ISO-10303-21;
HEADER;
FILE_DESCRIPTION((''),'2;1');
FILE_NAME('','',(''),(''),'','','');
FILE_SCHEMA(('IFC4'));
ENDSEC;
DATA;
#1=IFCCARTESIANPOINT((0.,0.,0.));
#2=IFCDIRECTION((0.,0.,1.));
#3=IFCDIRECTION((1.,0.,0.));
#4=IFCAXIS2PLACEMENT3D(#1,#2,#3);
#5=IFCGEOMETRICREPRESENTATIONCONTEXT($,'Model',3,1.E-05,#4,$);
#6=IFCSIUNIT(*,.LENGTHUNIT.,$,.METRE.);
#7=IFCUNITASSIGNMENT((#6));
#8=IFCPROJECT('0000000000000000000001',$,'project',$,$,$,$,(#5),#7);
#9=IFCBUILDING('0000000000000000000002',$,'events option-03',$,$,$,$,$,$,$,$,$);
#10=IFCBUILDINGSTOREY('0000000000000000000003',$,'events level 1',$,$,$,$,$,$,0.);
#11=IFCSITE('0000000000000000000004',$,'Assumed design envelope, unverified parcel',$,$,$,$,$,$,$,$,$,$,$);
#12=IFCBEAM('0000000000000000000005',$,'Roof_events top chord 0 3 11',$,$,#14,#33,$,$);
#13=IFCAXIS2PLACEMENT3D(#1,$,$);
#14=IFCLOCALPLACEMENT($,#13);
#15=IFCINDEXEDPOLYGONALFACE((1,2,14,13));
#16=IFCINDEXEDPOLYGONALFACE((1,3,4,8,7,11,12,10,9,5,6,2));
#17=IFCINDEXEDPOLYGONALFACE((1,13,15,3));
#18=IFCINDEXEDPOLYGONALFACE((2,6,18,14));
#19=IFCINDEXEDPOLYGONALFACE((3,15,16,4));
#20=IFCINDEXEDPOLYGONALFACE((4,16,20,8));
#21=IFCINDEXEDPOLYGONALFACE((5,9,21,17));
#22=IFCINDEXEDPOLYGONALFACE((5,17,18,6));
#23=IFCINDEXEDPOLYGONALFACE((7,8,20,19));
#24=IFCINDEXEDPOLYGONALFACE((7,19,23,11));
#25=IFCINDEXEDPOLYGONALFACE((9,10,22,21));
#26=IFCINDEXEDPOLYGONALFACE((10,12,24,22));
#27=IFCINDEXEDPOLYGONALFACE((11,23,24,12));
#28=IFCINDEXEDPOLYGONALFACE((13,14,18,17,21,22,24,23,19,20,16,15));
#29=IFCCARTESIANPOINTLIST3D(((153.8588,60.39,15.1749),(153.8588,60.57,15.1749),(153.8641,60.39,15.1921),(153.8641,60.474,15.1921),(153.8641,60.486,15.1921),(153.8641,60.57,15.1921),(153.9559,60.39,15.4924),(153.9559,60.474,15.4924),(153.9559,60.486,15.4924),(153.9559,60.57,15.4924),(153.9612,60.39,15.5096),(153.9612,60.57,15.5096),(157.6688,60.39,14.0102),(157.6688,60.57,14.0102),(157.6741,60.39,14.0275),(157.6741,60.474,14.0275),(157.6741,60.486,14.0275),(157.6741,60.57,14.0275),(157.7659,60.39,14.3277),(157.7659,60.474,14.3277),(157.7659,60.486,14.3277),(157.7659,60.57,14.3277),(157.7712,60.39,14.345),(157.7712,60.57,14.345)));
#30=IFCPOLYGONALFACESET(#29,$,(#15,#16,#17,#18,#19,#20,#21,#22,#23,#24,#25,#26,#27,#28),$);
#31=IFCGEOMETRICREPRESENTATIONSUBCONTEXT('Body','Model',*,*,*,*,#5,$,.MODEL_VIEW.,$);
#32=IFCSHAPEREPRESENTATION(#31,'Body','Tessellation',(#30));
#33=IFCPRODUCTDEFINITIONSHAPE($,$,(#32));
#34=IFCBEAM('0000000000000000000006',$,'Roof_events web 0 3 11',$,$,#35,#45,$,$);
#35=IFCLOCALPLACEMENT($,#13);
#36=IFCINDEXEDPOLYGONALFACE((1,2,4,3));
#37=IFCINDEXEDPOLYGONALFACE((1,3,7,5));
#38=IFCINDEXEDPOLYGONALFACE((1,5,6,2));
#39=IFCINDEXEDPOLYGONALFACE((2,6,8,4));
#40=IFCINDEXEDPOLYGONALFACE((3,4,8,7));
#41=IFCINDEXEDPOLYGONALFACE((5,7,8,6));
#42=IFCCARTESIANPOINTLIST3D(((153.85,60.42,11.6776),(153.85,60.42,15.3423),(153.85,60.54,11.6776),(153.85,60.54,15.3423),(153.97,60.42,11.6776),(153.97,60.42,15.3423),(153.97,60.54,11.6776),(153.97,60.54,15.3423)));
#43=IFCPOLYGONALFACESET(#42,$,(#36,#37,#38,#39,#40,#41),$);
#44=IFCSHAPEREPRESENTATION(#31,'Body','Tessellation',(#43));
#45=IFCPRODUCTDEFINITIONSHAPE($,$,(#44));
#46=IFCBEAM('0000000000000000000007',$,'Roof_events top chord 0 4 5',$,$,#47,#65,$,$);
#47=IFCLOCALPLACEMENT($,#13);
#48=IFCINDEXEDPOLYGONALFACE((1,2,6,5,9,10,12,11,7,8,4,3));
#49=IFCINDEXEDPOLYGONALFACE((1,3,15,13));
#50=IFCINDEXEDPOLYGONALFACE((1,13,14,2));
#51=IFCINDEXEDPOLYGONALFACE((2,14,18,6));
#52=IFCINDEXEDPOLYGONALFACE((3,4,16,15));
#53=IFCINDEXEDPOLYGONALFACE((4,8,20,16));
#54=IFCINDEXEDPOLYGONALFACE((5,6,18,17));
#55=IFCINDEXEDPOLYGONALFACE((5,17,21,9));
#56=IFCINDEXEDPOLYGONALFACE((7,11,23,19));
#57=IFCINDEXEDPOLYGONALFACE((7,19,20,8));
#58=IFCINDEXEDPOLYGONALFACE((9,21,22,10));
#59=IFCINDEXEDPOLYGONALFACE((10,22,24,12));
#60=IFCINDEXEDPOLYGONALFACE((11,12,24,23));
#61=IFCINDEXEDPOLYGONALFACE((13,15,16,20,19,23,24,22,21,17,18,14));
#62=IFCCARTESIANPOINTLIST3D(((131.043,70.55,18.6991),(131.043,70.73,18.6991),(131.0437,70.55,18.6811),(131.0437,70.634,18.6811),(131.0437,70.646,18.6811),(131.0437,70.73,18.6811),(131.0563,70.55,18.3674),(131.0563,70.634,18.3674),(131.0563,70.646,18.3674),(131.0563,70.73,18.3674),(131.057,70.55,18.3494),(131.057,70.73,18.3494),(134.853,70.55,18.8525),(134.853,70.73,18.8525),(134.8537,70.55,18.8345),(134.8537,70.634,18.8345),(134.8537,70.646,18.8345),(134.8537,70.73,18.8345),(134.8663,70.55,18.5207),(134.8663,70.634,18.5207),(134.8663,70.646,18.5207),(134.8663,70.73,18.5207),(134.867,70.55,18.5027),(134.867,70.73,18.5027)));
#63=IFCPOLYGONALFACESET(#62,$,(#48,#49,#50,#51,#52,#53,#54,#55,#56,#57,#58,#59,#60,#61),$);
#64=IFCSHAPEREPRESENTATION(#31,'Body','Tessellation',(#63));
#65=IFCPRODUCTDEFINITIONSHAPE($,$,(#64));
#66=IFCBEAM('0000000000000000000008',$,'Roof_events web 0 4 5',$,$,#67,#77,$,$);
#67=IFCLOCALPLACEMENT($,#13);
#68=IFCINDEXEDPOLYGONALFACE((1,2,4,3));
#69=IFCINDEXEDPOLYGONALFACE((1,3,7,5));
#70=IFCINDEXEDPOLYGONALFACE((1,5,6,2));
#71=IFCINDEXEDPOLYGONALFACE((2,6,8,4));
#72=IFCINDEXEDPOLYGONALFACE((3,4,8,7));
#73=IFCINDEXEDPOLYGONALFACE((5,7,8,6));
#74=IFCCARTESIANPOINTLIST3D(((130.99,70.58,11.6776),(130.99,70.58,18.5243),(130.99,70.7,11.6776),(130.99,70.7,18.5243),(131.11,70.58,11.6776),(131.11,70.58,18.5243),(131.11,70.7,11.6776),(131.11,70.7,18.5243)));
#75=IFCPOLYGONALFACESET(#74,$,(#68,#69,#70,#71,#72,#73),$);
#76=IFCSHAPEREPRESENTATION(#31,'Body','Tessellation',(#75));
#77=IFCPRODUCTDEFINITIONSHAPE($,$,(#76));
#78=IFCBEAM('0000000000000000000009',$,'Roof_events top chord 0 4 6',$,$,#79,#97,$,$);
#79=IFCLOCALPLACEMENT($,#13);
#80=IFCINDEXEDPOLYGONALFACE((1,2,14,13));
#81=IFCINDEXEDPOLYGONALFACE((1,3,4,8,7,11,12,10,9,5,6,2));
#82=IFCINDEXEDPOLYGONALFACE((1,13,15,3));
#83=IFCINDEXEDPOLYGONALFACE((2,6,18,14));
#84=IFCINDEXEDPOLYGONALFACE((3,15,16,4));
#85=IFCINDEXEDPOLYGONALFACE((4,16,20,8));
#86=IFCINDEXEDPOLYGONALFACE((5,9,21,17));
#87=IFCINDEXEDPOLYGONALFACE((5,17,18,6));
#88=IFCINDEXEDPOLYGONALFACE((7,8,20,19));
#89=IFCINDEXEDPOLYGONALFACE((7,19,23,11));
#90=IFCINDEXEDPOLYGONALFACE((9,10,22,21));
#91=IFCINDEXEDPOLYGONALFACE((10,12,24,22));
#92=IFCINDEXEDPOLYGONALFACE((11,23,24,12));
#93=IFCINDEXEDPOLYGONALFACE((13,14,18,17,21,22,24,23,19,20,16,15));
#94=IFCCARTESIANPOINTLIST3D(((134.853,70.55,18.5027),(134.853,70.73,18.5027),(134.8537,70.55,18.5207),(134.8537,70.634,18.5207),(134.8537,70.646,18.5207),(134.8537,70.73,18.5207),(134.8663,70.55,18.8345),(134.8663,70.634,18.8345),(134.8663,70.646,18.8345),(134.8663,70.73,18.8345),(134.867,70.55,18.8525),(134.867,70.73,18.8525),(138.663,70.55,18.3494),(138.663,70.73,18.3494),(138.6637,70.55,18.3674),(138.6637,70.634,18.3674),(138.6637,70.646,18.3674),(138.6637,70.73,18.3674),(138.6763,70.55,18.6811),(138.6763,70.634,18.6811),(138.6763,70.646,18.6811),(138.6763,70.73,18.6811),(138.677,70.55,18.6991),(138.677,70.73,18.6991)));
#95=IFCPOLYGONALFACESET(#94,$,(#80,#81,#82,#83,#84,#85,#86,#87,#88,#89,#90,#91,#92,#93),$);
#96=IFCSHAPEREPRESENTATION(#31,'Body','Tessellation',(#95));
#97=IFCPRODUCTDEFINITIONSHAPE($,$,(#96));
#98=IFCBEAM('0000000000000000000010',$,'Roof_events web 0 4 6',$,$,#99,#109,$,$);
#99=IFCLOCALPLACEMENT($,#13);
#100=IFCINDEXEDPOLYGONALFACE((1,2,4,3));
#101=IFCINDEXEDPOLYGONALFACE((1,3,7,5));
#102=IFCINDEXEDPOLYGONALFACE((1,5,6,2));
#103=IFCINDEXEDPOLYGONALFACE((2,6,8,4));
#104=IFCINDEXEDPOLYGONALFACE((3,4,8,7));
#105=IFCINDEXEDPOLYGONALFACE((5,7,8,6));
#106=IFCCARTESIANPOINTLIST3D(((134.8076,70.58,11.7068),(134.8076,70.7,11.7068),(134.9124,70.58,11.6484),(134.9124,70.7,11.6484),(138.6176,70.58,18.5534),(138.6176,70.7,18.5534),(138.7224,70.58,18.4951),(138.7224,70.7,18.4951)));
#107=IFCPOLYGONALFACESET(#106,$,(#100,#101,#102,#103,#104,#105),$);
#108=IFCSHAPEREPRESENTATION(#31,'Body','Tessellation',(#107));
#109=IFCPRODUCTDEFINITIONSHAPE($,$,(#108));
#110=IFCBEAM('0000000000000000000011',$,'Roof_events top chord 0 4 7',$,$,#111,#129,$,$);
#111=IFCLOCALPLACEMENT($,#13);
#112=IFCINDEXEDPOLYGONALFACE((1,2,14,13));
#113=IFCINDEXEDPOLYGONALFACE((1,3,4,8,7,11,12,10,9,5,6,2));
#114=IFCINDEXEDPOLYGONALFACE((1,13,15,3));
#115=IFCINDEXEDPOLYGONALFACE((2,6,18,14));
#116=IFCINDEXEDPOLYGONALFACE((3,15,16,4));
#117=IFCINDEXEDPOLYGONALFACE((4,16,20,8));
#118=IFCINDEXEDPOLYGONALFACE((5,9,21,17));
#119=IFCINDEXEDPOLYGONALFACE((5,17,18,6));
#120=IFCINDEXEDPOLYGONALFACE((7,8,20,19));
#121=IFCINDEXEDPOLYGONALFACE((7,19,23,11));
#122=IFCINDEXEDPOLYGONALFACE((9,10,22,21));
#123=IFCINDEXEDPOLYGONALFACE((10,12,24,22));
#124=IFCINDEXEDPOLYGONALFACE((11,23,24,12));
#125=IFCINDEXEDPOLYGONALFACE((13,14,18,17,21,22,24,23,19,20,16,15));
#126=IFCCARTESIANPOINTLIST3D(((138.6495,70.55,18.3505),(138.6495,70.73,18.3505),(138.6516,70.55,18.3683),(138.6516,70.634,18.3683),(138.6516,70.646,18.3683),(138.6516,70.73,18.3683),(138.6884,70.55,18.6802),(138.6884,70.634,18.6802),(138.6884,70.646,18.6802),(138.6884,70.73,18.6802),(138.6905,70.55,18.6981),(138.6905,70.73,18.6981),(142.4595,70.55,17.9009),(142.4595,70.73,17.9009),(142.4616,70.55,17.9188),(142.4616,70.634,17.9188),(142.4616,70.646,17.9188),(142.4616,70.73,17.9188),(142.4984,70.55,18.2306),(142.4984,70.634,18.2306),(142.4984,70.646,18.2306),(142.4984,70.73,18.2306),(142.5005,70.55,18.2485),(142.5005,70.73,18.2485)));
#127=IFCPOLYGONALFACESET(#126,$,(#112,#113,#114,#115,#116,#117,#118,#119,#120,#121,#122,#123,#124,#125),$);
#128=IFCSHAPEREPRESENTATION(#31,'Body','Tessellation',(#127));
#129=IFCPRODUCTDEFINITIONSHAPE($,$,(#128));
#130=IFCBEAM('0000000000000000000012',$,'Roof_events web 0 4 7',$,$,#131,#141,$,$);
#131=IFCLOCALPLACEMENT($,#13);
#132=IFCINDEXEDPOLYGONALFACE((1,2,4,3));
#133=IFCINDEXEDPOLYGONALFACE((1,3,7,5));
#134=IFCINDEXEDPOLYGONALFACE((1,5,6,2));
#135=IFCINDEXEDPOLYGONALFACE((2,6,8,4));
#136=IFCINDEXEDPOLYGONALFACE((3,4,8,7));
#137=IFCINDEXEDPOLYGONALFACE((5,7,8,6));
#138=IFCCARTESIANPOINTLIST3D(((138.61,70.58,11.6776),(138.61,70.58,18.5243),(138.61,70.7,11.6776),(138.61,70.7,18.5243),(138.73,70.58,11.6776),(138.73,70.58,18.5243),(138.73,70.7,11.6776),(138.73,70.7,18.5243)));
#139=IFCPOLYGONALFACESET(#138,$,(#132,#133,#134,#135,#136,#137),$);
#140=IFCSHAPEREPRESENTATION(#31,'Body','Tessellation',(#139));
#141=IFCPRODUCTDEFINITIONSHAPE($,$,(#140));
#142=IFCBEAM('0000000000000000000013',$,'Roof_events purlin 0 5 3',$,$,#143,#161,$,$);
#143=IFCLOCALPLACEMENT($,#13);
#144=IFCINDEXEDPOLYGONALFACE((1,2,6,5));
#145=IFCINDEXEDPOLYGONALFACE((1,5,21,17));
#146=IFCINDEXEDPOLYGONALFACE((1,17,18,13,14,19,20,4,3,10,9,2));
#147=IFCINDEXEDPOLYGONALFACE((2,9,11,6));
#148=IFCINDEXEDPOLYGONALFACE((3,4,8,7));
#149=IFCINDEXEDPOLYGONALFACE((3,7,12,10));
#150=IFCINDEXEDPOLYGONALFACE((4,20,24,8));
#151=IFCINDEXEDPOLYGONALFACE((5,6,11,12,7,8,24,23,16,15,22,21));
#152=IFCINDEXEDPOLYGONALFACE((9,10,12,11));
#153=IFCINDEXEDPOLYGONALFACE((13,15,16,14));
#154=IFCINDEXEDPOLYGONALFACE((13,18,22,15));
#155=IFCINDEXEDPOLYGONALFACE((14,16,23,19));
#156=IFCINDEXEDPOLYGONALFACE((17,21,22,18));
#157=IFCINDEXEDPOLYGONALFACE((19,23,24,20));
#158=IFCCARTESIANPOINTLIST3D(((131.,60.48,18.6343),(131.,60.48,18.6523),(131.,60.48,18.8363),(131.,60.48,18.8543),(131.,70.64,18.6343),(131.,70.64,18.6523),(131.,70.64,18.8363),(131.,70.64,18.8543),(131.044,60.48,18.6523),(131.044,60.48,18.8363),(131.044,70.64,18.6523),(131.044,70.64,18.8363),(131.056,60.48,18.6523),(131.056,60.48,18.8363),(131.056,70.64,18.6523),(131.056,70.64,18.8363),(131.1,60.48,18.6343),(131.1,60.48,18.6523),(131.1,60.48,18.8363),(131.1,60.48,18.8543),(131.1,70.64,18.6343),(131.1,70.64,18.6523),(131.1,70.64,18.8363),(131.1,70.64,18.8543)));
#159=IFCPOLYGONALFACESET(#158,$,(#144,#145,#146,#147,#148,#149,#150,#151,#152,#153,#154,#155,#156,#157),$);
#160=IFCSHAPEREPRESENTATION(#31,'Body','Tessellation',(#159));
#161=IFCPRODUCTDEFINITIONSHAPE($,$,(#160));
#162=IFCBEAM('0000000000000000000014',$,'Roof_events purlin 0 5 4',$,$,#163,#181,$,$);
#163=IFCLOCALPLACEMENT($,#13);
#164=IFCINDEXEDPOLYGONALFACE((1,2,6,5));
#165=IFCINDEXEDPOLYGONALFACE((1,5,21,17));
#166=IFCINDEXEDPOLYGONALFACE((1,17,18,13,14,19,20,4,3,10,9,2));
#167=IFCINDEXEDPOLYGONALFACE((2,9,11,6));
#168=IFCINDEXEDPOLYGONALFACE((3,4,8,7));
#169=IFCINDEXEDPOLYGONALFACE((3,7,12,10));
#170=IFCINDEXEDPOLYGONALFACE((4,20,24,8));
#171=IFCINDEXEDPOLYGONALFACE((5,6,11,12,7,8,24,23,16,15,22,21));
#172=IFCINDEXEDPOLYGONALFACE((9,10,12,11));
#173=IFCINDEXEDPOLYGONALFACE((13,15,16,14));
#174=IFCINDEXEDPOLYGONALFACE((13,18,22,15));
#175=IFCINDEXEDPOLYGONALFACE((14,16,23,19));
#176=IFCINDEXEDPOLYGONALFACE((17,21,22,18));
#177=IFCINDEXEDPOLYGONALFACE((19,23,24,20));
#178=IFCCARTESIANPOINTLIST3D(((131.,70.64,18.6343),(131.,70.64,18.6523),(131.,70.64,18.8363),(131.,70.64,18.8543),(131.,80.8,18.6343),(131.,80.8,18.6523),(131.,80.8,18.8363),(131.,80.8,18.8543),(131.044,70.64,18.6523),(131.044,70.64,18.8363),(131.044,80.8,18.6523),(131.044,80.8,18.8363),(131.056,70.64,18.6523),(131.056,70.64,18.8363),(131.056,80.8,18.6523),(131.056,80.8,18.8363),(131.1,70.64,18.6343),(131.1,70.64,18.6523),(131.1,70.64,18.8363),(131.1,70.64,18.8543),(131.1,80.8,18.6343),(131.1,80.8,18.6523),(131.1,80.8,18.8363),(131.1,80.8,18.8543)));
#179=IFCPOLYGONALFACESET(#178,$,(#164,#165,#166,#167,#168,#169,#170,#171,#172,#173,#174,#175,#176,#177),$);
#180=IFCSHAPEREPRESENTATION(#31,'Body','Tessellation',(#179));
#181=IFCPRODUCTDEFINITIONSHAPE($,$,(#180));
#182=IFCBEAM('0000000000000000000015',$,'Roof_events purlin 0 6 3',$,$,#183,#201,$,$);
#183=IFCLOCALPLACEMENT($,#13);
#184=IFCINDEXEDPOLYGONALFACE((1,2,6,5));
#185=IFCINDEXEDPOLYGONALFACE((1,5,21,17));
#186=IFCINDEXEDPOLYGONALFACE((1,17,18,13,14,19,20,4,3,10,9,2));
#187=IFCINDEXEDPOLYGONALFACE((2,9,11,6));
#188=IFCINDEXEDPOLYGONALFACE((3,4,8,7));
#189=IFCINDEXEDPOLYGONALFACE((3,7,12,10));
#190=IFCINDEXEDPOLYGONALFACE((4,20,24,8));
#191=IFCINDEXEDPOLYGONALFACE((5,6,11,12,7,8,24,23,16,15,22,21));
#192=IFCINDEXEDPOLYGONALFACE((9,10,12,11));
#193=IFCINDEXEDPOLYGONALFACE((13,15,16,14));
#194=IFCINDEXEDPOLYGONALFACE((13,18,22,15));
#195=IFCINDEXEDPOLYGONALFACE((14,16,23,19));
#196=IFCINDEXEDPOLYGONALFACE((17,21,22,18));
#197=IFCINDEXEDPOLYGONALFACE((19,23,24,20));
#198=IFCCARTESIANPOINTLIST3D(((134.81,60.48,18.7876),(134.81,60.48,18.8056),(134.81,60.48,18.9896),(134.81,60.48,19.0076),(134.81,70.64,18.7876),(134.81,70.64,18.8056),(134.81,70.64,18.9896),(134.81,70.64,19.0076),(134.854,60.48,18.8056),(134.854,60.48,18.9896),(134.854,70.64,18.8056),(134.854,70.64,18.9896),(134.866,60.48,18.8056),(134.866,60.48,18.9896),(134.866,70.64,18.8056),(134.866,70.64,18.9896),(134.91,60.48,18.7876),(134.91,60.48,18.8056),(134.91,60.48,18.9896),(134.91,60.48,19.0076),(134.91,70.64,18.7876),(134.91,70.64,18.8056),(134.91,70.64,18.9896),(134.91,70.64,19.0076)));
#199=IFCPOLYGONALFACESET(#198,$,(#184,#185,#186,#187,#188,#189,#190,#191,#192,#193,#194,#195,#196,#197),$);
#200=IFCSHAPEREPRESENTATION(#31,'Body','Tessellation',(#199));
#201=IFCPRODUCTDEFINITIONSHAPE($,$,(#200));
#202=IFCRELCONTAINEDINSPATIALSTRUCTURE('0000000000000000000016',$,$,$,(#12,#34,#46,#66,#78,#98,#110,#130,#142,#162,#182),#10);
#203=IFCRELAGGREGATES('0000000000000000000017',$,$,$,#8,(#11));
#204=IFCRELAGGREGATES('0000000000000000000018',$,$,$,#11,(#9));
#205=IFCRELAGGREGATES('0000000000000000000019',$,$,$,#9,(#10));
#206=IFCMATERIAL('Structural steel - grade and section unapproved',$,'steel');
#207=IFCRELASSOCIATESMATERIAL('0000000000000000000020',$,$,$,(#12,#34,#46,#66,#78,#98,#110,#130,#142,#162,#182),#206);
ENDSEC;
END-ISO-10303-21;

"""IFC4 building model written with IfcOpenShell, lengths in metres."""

from ifc_helpers import new_model, si_unit, frame, origin_with_axes, place, context, subcontext, project, spatial, rectangle, i_section, extrude, material, element, save


model = new_model("IFC4")

# Units and contexts
model_context = context("Model", 3, precision=1e-05, world=origin_with_axes())
body_context = subcontext(model_context, "Body", "Model", "MODEL_VIEW")
ifc_project = project(units=[si_unit("LENGTHUNIT", "METRE")], contexts=[model_context])

# Site, building, storey
site = spatial("IfcSite", under=ifc_project, Name="Assumed design envelope, unverified parcel")
building = spatial("IfcBuilding", under=site, Name="events option-03")
storey = spatial("IfcBuildingStorey", under=building, Name="events level 1", Elevation=0.0)

# Beams
ifc_material = material(Name="Structural steel - grade and section unapproved", Category="steel")
beam_1_placement = place(None, frame((153.91, 60.48, 15.3423), z_axis=(0.956315, 0.0, -0.292338), x_axis=(0.0, 1.0, 0.0)))
element("IfcBeam", 1, at=beam_1_placement, inside=storey, material=ifc_material, Name="Roof_events top chord 0 3 11", context=body_context, shape_type="SweptSolid", body=[
    extrude(i_section(OverallWidth=0.18, OverallDepth=0.35, WebThickness=0.012, FlangeThickness=0.018, FilletRadius=0.0), origin_with_axes(), (0.0, 0.0, 1.0), 3.984),
])
beam_2_placement = place(None, frame((153.91, 60.48, 11.6776), z_axis=(0.0, 0.0, 1.0), x_axis=(-1.0, 0.0, 0.0)))
element("IfcBeam", 2, at=beam_2_placement, inside=storey, material=ifc_material, Name="Roof_events web 0 3 11", context=body_context, shape_type="SweptSolid", body=[
    extrude(rectangle(XDim=0.12, YDim=0.12), origin_with_axes(), (0.0, 0.0, 1.0), 3.6647),
])
beam_3_placement = place(None, frame((131.05, 70.64, 18.5243), z_axis=(0.999191, 0.0, 0.040213), x_axis=(0.0, 1.0, 0.0)))
element("IfcBeam", 3, at=beam_3_placement, inside=storey, material=ifc_material, Name="Roof_events top chord 0 4 5", context=body_context, shape_type="SweptSolid", body=[
    extrude(i_section(OverallWidth=0.18, OverallDepth=0.35, WebThickness=0.012, FlangeThickness=0.018, FilletRadius=0.0), origin_with_axes(), (0.0, 0.0, 1.0), 3.8131),
])
beam_4_placement = place(None, frame((131.05, 70.64, 11.6776), z_axis=(0.0, 0.0, 1.0), x_axis=(-1.0, 0.0, 0.0)))
element("IfcBeam", 4, at=beam_4_placement, inside=storey, material=ifc_material, Name="Roof_events web 0 4 5", context=body_context, shape_type="SweptSolid", body=[
    extrude(rectangle(XDim=0.12, YDim=0.12), origin_with_axes(), (0.0, 0.0, 1.0), 6.8467),
])
beam_5_placement = place(None, frame((134.86, 70.64, 18.6776), z_axis=(0.999191, 0.0, -0.040212), x_axis=(0.0, 1.0, 0.0)))
element("IfcBeam", 5, at=beam_5_placement, inside=storey, material=ifc_material, Name="Roof_events top chord 0 4 6", context=body_context, shape_type="SweptSolid", body=[
    extrude(i_section(OverallWidth=0.18, OverallDepth=0.35, WebThickness=0.012, FlangeThickness=0.018, FilletRadius=0.0), origin_with_axes(), (0.0, 0.0, 1.0), 3.8131),
])
beam_6_placement = place(None, frame((134.86, 70.64, 11.6776), z_axis=(0.486257, 0.0, 0.873816), x_axis=(0.0, 1.0, 0.0)))
element("IfcBeam", 6, at=beam_6_placement, inside=storey, material=ifc_material, Name="Roof_events web 0 4 6", context=body_context, shape_type="SweptSolid", body=[
    extrude(rectangle(XDim=0.12, YDim=0.12), origin_with_axes(), (0.0, 0.0, 1.0), 7.8354),
])
beam_7_placement = place(None, frame((138.67, 70.64, 18.5243), z_axis=(0.993111, 0.0, -0.11718), x_axis=(0.0, 1.0, 0.0)))
element("IfcBeam", 7, at=beam_7_placement, inside=storey, material=ifc_material, Name="Roof_events top chord 0 4 7", context=body_context, shape_type="SweptSolid", body=[
    extrude(i_section(OverallWidth=0.18, OverallDepth=0.35, WebThickness=0.012, FlangeThickness=0.018, FilletRadius=0.0), origin_with_axes(), (0.0, 0.0, 1.0), 3.8364),
])
beam_8_placement = place(None, frame((138.67, 70.64, 11.6776), z_axis=(0.0, 0.0, 1.0), x_axis=(-1.0, 0.0, 0.0)))
element("IfcBeam", 8, at=beam_8_placement, inside=storey, material=ifc_material, Name="Roof_events web 0 4 7", context=body_context, shape_type="SweptSolid", body=[
    extrude(rectangle(XDim=0.12, YDim=0.12), origin_with_axes(), (0.0, 0.0, 1.0), 6.8467),
])
beam_9_placement = place(None, frame((131.05, 60.48, 18.7443), z_axis=(0.0, 1.0, 0.0), x_axis=(-1.0, 0.0, 0.0)))
element("IfcBeam", 9, at=beam_9_placement, inside=storey, material=ifc_material, Name="Roof_events purlin 0 5 3", context=body_context, shape_type="SweptSolid", body=[
    extrude(i_section(OverallWidth=0.1, OverallDepth=0.22, WebThickness=0.012, FlangeThickness=0.018, FilletRadius=0.0), origin_with_axes(), (0.0, 0.0, 1.0), 10.16),
])
beam_10_placement = place(None, frame((131.05, 70.64, 18.7443), z_axis=(0.0, 1.0, 0.0), x_axis=(-1.0, 0.0, 0.0)))
element("IfcBeam", 10, at=beam_10_placement, inside=storey, material=ifc_material, Name="Roof_events purlin 0 5 4", context=body_context, shape_type="SweptSolid", body=[
    extrude(i_section(OverallWidth=0.1, OverallDepth=0.22, WebThickness=0.012, FlangeThickness=0.018, FilletRadius=0.0), origin_with_axes(), (0.0, 0.0, 1.0), 10.16),
])
beam_11_placement = place(None, frame((134.86, 60.48, 18.8976), z_axis=(0.0, 1.0, 0.0), x_axis=(-1.0, 0.0, 0.0)))
element("IfcBeam", 11, at=beam_11_placement, inside=storey, material=ifc_material, Name="Roof_events purlin 0 6 3", context=body_context, shape_type="SweptSolid", body=[
    extrude(i_section(OverallWidth=0.1, OverallDepth=0.22, WebThickness=0.012, FlangeThickness=0.018, FilletRadius=0.0), origin_with_axes(), (0.0, 0.0, 1.0), 10.16),
])

save(model, "model.ifc")
